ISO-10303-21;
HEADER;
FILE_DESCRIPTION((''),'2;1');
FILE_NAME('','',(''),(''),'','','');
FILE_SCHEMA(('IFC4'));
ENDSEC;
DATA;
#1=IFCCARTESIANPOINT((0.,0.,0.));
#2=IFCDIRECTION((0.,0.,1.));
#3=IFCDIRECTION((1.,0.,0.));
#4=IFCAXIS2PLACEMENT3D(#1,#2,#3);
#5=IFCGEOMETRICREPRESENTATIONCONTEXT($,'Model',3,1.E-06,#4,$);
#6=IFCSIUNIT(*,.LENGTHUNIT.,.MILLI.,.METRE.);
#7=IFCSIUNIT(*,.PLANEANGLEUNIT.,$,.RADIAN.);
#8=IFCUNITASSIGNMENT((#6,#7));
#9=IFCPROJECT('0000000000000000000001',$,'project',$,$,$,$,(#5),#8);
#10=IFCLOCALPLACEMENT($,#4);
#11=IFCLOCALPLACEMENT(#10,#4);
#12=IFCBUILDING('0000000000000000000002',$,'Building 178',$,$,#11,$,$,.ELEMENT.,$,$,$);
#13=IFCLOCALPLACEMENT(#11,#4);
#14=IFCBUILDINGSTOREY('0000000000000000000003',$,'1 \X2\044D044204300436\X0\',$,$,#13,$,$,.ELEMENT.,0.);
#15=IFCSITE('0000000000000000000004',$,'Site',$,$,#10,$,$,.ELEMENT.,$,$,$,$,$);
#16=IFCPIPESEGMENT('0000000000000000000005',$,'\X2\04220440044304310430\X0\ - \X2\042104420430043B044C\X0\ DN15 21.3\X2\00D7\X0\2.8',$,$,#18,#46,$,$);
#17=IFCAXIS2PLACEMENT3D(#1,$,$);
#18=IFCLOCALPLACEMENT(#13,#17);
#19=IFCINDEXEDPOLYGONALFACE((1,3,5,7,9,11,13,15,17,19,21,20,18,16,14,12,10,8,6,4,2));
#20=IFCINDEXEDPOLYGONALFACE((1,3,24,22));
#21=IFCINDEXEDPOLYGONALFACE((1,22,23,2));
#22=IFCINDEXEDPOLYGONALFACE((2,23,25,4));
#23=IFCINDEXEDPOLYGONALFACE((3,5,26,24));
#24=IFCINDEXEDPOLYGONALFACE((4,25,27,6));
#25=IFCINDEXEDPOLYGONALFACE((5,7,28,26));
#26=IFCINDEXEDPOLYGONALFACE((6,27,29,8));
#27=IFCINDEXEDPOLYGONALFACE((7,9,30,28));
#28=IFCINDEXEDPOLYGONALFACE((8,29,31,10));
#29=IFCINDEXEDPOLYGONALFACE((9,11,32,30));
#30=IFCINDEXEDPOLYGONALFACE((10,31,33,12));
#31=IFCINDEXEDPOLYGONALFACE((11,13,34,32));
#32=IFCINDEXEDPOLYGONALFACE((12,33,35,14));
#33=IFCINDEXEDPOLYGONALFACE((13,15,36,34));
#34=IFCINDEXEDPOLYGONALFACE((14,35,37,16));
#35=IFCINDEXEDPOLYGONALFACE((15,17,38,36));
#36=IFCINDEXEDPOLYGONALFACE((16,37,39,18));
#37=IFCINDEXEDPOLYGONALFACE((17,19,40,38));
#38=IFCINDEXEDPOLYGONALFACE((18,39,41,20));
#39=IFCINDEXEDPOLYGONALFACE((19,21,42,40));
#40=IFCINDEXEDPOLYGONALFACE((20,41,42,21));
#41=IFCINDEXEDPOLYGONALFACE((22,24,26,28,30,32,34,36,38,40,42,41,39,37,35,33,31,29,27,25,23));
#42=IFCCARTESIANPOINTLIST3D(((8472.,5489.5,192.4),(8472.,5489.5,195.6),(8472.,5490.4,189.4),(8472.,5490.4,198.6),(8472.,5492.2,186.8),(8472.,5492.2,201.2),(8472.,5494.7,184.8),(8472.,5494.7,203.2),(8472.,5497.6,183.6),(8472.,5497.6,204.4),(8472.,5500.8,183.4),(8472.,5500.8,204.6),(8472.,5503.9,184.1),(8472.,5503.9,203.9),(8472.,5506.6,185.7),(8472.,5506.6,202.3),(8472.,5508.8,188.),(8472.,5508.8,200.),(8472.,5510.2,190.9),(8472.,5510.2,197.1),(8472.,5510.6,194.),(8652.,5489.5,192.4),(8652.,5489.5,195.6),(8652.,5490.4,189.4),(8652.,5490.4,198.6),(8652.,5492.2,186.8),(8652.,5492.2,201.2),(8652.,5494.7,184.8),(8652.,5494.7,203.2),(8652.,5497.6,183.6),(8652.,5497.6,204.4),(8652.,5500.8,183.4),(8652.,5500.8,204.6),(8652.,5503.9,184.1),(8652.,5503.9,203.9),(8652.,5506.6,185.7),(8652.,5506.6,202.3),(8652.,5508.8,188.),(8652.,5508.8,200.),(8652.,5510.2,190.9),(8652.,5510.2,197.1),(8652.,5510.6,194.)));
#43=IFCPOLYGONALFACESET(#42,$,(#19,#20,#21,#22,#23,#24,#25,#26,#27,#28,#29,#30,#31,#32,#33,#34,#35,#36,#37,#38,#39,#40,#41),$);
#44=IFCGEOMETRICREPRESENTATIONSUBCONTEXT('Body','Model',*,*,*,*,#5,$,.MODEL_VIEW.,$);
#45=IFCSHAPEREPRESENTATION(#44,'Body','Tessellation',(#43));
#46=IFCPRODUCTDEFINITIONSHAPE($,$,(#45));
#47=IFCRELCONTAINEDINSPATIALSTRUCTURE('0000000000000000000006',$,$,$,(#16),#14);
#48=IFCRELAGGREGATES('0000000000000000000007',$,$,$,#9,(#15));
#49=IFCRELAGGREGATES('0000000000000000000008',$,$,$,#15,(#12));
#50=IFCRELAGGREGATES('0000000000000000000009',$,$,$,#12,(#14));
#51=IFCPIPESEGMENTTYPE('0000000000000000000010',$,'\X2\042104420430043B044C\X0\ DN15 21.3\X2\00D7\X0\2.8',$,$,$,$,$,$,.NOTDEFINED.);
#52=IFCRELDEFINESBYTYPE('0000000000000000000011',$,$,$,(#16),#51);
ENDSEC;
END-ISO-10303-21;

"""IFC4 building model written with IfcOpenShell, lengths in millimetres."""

from ifc_helpers import new_model, entity, si_unit, frame, origin_with_axes, place, context, subcontext, project, spatial, source, transform, mapped, type_object, element, save


model = new_model("IFC4")

# Units and contexts
model_context = context("Model", 3, precision=1e-06, world=origin_with_axes())
body_context = subcontext(model_context, "Body", "Model", "MODEL_VIEW")
ifc_project = project(units=[si_unit("LENGTHUNIT", "METRE", prefix="MILLI"), si_unit("PLANEANGLEUNIT", "RADIAN")], contexts=[model_context])

# Site, building, storey
site_placement = place(None, origin_with_axes())
site = spatial("IfcSite", under=ifc_project, at=site_placement, Name="Site", CompositionType="ELEMENT")
building_placement = place(site_placement, origin_with_axes())
building = spatial("IfcBuilding", under=site, at=building_placement, Name="Building 178", CompositionType="ELEMENT")
storey_placement = place(building_placement, origin_with_axes())
storey = spatial("IfcBuildingStorey", under=building, at=storey_placement, Name="1 этаж", CompositionType="ELEMENT", Elevation=0.0)

# Pipe segment
pipe_segment_type = type_object("IfcPipeSegmentType", Name="Сталь DN15 21.3×2.8", PredefinedType="NOTDEFINED")
shared_shape_1 = source(origin_with_axes(), body_context, "Body", "AdvancedSweptSolid", [
    entity("IfcSweptDiskSolid", entity("IfcIndexedPolyCurve", entity("IfcCartesianPointList3D", [[0.0, 0.0, 0.0], [0.0, 0.0, -180.0]]), [entity("IfcLineIndex", [1, 2])]), 10.7),
])
for number, where, z_axis, x_axis, name in (
    (1, (8472.0, 5500.0, 194.0), (-1.0, 0.0, 0.0), (0.0, -1.0, 0.0), "Труба - Сталь DN15 21.3×2.8"),
):
    element("IfcPipeSegment", number, at=place(storey_placement, frame(where, z_axis=z_axis, x_axis=x_axis)), inside=storey, type_object=pipe_segment_type, Name=name, context=body_context, shape_type="MappedRepresentation", body=[
        mapped(shared_shape_1, transform((0.0, 0.0, 0.0), x_axis=(1.0, 0.0, 0.0), y_axis=(0.0, 1.0, 0.0), z_axis=(0.0, 0.0, 1.0), scale=1.0)),
    ])

save(model, "model.ifc")
